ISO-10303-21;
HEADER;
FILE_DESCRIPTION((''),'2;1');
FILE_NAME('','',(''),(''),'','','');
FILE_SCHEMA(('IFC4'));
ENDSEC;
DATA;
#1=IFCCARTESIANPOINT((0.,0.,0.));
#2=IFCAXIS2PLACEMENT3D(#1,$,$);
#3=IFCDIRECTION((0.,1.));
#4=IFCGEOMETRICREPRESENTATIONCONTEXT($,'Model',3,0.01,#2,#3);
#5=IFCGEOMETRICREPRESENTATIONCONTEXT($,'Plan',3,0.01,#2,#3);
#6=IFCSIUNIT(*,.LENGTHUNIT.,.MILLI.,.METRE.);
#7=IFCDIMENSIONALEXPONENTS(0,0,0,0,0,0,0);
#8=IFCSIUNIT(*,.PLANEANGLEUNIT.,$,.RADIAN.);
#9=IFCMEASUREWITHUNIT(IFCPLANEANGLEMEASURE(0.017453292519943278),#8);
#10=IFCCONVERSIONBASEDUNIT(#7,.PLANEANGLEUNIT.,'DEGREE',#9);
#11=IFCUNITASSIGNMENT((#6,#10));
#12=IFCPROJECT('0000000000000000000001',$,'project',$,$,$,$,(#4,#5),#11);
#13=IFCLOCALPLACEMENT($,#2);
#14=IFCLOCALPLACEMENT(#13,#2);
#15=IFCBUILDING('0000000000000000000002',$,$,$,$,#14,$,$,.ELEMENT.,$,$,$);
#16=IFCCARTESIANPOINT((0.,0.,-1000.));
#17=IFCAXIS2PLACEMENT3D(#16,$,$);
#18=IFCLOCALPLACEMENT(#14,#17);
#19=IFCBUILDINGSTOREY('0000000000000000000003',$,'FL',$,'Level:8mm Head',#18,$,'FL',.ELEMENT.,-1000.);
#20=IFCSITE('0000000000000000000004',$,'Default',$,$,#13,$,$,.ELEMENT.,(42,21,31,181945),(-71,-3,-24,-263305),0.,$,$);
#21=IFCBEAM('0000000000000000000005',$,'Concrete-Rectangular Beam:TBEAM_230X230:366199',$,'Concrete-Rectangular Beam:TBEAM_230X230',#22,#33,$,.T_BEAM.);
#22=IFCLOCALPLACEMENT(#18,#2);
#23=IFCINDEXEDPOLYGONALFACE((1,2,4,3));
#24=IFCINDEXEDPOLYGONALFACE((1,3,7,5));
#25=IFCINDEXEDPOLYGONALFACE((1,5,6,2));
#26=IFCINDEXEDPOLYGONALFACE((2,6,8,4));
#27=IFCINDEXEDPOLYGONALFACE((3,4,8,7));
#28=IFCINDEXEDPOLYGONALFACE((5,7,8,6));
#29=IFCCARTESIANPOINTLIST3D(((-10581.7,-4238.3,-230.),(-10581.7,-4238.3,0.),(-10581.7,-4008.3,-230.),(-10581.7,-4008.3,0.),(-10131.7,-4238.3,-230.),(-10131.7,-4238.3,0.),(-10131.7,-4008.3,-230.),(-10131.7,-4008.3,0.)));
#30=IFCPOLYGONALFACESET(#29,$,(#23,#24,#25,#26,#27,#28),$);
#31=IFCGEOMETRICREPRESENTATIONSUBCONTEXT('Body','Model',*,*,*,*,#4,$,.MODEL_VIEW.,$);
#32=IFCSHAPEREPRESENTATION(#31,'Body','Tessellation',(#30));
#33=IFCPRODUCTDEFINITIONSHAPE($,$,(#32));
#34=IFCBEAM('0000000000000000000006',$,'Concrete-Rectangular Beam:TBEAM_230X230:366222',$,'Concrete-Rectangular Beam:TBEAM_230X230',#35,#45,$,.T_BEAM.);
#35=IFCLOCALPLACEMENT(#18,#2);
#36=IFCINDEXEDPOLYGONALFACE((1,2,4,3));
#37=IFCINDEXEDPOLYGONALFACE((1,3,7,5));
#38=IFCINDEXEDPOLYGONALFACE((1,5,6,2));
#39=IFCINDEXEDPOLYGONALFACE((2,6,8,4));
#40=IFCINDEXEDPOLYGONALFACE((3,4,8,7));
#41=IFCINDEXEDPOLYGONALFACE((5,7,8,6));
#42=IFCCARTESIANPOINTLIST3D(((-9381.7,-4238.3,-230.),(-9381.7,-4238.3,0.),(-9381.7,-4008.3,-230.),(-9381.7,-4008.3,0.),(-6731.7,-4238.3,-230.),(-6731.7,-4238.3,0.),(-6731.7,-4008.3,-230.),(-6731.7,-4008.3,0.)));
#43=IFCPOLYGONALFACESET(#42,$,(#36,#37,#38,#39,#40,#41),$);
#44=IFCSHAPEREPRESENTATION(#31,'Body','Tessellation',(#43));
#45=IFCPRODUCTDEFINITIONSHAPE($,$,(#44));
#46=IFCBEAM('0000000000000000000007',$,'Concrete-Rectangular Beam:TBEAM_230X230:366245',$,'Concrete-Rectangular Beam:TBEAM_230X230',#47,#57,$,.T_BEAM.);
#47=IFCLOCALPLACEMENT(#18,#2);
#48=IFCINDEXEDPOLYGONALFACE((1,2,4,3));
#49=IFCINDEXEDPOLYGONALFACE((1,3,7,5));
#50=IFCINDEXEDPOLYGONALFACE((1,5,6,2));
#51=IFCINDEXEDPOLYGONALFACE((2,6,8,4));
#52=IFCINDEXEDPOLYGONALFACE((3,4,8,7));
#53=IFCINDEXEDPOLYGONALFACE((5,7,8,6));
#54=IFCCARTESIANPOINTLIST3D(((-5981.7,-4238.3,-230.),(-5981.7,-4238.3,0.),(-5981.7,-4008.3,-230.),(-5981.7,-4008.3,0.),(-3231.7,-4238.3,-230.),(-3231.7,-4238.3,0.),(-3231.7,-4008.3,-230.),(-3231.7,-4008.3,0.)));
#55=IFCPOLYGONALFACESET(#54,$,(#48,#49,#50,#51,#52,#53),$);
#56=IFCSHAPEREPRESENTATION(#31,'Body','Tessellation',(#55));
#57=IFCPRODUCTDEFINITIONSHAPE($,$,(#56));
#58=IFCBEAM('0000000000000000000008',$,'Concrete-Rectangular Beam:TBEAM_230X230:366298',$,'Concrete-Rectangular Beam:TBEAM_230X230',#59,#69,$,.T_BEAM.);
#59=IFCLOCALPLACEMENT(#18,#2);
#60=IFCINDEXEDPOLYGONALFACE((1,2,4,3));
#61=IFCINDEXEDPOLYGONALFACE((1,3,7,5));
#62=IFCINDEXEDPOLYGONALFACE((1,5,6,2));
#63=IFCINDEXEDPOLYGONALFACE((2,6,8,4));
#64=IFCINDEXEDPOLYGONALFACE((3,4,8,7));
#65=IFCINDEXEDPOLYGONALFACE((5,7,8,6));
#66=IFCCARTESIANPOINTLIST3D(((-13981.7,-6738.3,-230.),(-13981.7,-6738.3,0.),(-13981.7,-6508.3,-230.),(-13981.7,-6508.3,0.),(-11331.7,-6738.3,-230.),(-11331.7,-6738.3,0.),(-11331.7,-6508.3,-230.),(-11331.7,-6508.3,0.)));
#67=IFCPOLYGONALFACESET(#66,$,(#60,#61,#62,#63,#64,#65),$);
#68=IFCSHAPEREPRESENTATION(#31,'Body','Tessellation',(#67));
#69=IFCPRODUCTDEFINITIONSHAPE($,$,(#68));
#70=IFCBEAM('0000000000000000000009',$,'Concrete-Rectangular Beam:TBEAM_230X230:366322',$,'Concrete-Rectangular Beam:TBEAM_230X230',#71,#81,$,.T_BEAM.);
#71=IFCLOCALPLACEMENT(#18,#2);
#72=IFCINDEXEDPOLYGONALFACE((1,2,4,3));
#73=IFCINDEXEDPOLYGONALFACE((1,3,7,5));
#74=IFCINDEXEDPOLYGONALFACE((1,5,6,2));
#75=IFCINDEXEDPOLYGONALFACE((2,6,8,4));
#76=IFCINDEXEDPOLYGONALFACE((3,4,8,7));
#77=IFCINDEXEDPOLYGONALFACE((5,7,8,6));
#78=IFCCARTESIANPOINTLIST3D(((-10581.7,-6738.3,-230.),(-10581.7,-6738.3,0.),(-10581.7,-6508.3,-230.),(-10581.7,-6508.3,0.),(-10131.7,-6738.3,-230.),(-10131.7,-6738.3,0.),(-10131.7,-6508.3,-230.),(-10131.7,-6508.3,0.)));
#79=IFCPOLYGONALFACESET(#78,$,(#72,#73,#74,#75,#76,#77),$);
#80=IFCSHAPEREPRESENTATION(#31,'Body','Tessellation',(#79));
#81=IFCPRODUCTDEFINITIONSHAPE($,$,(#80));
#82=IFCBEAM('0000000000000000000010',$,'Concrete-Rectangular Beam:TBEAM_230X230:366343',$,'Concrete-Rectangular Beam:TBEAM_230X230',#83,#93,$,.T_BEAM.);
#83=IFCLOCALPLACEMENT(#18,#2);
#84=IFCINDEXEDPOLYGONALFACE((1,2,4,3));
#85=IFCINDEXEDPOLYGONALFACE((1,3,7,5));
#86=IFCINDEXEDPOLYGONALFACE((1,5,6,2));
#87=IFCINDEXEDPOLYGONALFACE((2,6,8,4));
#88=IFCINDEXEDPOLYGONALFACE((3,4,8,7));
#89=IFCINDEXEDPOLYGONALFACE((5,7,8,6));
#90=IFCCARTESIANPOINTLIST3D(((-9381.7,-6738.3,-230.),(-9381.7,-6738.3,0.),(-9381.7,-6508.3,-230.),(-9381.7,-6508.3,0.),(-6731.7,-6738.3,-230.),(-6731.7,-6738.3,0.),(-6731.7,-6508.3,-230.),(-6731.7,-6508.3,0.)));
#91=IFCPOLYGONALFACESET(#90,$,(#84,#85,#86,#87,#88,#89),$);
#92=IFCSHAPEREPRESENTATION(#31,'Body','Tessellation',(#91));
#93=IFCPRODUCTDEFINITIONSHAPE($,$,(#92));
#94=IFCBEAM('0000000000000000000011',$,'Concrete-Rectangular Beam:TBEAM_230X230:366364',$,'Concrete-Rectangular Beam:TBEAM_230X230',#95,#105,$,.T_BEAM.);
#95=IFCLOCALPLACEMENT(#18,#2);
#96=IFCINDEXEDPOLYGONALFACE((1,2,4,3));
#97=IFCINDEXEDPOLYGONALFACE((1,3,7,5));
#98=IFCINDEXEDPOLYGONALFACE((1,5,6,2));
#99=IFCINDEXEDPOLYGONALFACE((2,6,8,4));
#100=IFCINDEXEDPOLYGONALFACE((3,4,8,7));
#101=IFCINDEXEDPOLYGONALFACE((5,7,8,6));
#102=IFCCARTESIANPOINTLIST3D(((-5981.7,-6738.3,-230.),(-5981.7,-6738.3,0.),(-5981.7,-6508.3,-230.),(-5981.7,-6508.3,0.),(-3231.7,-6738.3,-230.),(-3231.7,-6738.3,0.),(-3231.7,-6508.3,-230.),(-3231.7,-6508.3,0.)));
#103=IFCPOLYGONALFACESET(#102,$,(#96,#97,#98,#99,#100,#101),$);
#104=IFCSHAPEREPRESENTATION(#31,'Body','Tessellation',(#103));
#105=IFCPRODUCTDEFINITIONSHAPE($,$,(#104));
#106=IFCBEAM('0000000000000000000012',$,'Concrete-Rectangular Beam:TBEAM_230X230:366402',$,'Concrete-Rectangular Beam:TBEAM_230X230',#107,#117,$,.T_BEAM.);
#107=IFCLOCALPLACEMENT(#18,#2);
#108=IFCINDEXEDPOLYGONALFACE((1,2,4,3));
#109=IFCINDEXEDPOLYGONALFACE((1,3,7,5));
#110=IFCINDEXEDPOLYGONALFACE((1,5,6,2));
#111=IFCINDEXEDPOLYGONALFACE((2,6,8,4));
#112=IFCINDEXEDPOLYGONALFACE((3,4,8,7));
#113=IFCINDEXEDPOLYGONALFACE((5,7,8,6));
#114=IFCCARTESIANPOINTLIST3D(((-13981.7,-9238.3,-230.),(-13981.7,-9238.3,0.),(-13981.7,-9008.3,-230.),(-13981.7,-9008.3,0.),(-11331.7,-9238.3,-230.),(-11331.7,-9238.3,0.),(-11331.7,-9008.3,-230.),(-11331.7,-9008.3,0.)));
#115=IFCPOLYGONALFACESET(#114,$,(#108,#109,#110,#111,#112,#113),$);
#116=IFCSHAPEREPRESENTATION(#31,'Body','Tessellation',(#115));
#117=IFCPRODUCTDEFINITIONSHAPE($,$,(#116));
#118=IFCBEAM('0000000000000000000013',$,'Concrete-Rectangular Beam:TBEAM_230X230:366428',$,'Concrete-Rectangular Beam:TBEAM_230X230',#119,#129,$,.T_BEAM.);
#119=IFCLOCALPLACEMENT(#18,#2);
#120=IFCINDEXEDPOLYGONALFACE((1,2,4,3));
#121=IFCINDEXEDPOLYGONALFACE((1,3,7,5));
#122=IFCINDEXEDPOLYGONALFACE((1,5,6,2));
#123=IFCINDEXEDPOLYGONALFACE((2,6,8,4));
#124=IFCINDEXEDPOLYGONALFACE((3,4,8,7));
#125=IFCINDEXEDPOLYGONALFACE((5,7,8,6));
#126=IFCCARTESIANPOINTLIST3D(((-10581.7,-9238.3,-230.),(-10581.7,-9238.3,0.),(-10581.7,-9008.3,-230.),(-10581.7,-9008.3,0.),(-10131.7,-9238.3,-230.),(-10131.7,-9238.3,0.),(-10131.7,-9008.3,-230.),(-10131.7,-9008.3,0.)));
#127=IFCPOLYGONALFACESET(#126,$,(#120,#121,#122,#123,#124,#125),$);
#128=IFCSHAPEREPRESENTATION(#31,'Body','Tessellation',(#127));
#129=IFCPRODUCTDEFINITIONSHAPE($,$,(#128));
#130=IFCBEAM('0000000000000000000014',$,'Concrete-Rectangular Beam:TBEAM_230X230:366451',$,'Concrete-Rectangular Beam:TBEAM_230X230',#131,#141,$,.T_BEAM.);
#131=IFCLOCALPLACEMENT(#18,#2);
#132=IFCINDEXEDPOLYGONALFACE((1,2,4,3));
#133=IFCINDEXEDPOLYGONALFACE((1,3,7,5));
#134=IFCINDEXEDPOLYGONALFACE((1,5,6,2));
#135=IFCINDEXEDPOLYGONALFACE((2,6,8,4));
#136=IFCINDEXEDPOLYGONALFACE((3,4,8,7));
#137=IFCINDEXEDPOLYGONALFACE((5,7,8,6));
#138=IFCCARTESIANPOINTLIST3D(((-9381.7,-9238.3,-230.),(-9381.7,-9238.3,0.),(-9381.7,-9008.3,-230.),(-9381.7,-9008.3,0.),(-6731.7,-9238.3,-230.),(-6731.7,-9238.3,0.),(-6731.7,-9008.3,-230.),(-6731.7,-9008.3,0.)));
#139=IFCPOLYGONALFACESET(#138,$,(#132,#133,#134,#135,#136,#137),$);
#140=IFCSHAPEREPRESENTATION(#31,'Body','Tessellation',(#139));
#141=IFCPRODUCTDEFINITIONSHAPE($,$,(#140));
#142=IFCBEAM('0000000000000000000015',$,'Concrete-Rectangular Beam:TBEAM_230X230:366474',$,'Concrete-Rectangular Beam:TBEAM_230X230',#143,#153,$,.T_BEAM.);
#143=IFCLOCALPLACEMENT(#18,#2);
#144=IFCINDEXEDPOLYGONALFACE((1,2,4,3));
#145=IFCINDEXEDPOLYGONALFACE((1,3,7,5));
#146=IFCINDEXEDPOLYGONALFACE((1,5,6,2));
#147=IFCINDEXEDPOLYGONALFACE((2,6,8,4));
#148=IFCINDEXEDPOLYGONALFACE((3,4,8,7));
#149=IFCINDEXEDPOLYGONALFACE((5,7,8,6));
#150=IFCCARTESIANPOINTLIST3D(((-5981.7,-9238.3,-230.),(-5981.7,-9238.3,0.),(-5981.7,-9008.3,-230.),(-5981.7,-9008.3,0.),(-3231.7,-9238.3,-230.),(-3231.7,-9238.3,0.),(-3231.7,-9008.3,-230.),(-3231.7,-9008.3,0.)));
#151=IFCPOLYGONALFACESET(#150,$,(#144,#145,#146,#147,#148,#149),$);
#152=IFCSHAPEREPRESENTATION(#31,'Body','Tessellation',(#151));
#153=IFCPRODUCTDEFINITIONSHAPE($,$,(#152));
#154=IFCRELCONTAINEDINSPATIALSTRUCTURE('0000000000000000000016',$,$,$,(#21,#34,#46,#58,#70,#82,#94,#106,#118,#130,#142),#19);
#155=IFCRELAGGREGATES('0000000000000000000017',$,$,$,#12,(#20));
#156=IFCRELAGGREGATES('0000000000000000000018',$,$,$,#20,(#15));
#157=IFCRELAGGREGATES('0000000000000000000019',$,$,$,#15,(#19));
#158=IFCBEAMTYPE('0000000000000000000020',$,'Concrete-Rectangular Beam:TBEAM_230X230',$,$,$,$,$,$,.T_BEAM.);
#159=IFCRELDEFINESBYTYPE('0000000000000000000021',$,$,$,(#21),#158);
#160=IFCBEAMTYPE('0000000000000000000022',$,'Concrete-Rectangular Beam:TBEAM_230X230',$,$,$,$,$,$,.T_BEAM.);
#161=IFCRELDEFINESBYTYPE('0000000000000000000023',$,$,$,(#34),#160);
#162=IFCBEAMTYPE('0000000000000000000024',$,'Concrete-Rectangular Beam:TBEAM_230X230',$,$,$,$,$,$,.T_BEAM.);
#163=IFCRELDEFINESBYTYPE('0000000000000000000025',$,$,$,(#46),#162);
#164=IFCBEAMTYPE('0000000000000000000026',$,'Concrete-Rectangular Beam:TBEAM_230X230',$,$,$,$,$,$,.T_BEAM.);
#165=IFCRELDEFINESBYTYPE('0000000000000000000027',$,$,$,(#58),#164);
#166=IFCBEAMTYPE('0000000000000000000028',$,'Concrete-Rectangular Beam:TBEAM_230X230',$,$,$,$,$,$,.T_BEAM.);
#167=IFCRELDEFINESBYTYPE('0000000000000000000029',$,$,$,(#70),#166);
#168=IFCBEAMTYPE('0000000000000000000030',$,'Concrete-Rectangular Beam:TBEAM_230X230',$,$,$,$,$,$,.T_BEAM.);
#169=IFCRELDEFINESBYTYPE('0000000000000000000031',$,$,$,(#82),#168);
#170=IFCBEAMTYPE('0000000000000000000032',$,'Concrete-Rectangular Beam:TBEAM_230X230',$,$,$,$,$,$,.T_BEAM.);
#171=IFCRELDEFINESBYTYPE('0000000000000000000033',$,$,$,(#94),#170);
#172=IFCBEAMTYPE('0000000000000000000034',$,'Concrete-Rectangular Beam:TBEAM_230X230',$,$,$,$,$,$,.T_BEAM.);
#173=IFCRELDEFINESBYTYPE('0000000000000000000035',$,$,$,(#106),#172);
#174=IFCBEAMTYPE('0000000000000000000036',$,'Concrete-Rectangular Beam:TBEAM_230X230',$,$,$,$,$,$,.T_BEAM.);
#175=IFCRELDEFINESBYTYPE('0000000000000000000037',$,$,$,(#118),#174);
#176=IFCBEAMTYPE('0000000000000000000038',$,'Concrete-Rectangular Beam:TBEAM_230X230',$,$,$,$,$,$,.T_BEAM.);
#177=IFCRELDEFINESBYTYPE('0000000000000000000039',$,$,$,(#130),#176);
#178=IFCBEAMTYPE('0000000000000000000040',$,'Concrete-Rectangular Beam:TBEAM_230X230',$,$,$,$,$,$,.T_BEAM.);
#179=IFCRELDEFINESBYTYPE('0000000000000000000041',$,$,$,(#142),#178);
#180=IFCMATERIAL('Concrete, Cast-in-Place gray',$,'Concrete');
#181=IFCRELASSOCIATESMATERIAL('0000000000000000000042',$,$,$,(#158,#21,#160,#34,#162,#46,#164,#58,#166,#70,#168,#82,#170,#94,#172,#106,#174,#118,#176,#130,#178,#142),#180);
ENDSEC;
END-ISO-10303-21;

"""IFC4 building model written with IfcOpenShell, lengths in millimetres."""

from ifc_helpers import new_model, entity, si_unit, converted_unit, direction, frame, origin, place, context, subcontext, project, spatial, indexed_curve, outline, extrude, source, transform, mapped, material, type_object, type_shapes, element, save


model = new_model("IFC4")

# Units and contexts
model_context = context("Model", 3, precision=0.01, world=origin(), true_north=direction((0.0, 1.0)))
plan_context = context("Plan", 3, precision=0.01, world=origin(), true_north=direction((0.0, 1.0)))
body_context = subcontext(model_context, "Body", "Model", "MODEL_VIEW")
ifc_project = project(units=[si_unit("LENGTHUNIT", "METRE", prefix="MILLI"), converted_unit("PLANEANGLEUNIT", "DEGREE", entity("IfcPlaneAngleMeasure", 0.017453292519943278), si_unit("PLANEANGLEUNIT", "RADIAN"), dimensions=[0, 0, 0, 0, 0, 0, 0])], contexts=[model_context, plan_context])

# Site, building, storey
site_placement = place(None, origin())
site = spatial("IfcSite", under=ifc_project, at=site_placement, Name="Default", CompositionType="ELEMENT", RefLatitude=(42, 21, 31, 181945), RefLongitude=(-71, -3, -24, -263305), RefElevation=0.0)
building_placement = place(site_placement, origin())
building = spatial("IfcBuilding", under=site, at=building_placement, CompositionType="ELEMENT")
storey_placement = place(building_placement, frame((0.0, 0.0, -1000.0)))
storey = spatial("IfcBuildingStorey", under=building, at=storey_placement, Name="FL", ObjectType="Level:8mm Head", LongName="FL", CompositionType="ELEMENT", Elevation=-1000.0)

# Shared definitions
ifc_material = material(Name="Concrete, Cast-in-Place gray", Category="Concrete")

# Beams
beam_type_1 = type_object("IfcBeamType", Name="Concrete-Rectangular Beam:TBEAM_230X230", PredefinedType="T_BEAM", material=ifc_material)
shared_shape_1 = source(origin(), body_context, "Body", "SweptSolid", [
    extrude(outline(indexed_curve([(-115.0, -115.0), (115.0, -115.0), (115.0, 115.0), (-115.0, 115.0), (-115.0, -115.0)], self_intersect=False)), frame((-10581.7, -4123.3, -1115.0), z_axis=(1.0, 0.0, 0.0), x_axis=(0.0, 0.0, -1.0)), (0.0, 0.0, 1.0), 450.0),
])
type_shapes(beam_type_1, [shared_shape_1])
beam_1_placement = place(storey_placement, frame((0.0, 0.0, 1000.0)))
element("IfcBeam", 1, at=beam_1_placement, inside=storey, type_object=beam_type_1, material=ifc_material, Name="Concrete-Rectangular Beam:TBEAM_230X230:366199", ObjectType="Concrete-Rectangular Beam:TBEAM_230X230", PredefinedType="T_BEAM", context=body_context, shape_type="MappedRepresentation", body=[
    mapped(shared_shape_1, transform((0.0, 0.0, 0.0), scale=1.0)),
])
beam_type_2 = type_object("IfcBeamType", Name="Concrete-Rectangular Beam:TBEAM_230X230", PredefinedType="T_BEAM", material=ifc_material)
shared_shape_2 = source(origin(), body_context, "Body", "SweptSolid", [
    extrude(outline(indexed_curve([(-115.0, -115.0), (115.0, -115.0), (115.0, 115.0), (-115.0, 115.0), (-115.0, -115.0)], self_intersect=False)), frame((-9381.7, -4123.3, -1115.0), z_axis=(1.0, 0.0, 0.0), x_axis=(0.0, 0.0, -1.0)), (0.0, 0.0, 1.0), 2650.0),
])
type_shapes(beam_type_2, [shared_shape_2])
beam_2_placement = place(storey_placement, frame((0.0, 0.0, 1000.0)))
element("IfcBeam", 2, at=beam_2_placement, inside=storey, type_object=beam_type_2, material=ifc_material, Name="Concrete-Rectangular Beam:TBEAM_230X230:366222", ObjectType="Concrete-Rectangular Beam:TBEAM_230X230", PredefinedType="T_BEAM", context=body_context, shape_type="MappedRepresentation", body=[
    mapped(shared_shape_2, transform((0.0, 0.0, 0.0), scale=1.0)),
])
beam_type_3 = type_object("IfcBeamType", Name="Concrete-Rectangular Beam:TBEAM_230X230", PredefinedType="T_BEAM", material=ifc_material)
shared_shape_3 = source(origin(), body_context, "Body", "SweptSolid", [
    extrude(outline(indexed_curve([(-115.0, -115.0), (115.0, -115.0), (115.0, 115.0), (-115.0, 115.0), (-115.0, -115.0)], self_intersect=False)), frame((-5981.7, -4123.3, -1115.0), z_axis=(1.0, 0.0, 0.0), x_axis=(0.0, 0.0, -1.0)), (0.0, 0.0, 1.0), 2750.0),
])
type_shapes(beam_type_3, [shared_shape_3])
beam_3_placement = place(storey_placement, frame((0.0, 0.0, 1000.0)))
element("IfcBeam", 3, at=beam_3_placement, inside=storey, type_object=beam_type_3, material=ifc_material, Name="Concrete-Rectangular Beam:TBEAM_230X230:366245", ObjectType="Concrete-Rectangular Beam:TBEAM_230X230", PredefinedType="T_BEAM", context=body_context, shape_type="MappedRepresentation", body=[
    mapped(shared_shape_3, transform((0.0, 0.0, 0.0), scale=1.0)),
])
beam_type_4 = type_object("IfcBeamType", Name="Concrete-Rectangular Beam:TBEAM_230X230", PredefinedType="T_BEAM", material=ifc_material)
shared_shape_4 = source(origin(), body_context, "Body", "SweptSolid", [
    extrude(outline(indexed_curve([(-115.0, -115.0), (115.0, -115.0), (115.0, 115.0), (-115.0, 115.0), (-115.0, -115.0)], self_intersect=False)), frame((-13981.7, -6623.3, -1115.0), z_axis=(1.0, 0.0, 0.0), x_axis=(0.0, 0.0, -1.0)), (0.0, 0.0, 1.0), 2650.0),
])
type_shapes(beam_type_4, [shared_shape_4])
beam_4_placement = place(storey_placement, frame((0.0, 0.0, 1000.0)))
element("IfcBeam", 4, at=beam_4_placement, inside=storey, type_object=beam_type_4, material=ifc_material, Name="Concrete-Rectangular Beam:TBEAM_230X230:366298", ObjectType="Concrete-Rectangular Beam:TBEAM_230X230", PredefinedType="T_BEAM", context=body_context, shape_type="MappedRepresentation", body=[
    mapped(shared_shape_4, transform((0.0, 0.0, 0.0), scale=1.0)),
])
beam_type_5 = type_object("IfcBeamType", Name="Concrete-Rectangular Beam:TBEAM_230X230", PredefinedType="T_BEAM", material=ifc_material)
shared_shape_5 = source(origin(), body_context, "Body", "SweptSolid", [
    extrude(outline(indexed_curve([(-115.0, -115.0), (115.0, -115.0), (115.0, 115.0), (-115.0, 115.0), (-115.0, -115.0)], self_intersect=False)), frame((-10581.7, -6623.3, -1115.0), z_axis=(1.0, 0.0, 0.0), x_axis=(0.0, 0.0, -1.0)), (0.0, 0.0, 1.0), 450.0),
])
type_shapes(beam_type_5, [shared_shape_5])
beam_5_placement = place(storey_placement, frame((0.0, 0.0, 1000.0)))
element("IfcBeam", 5, at=beam_5_placement, inside=storey, type_object=beam_type_5, material=ifc_material, Name="Concrete-Rectangular Beam:TBEAM_230X230:366322", ObjectType="Concrete-Rectangular Beam:TBEAM_230X230", PredefinedType="T_BEAM", context=body_context, shape_type="MappedRepresentation", body=[
    mapped(shared_shape_5, transform((0.0, 0.0, 0.0), scale=1.0)),
])
beam_type_6 = type_object("IfcBeamType", Name="Concrete-Rectangular Beam:TBEAM_230X230", PredefinedType="T_BEAM", material=ifc_material)
shared_shape_6 = source(origin(), body_context, "Body", "SweptSolid", [
    extrude(outline(indexed_curve([(-115.0, -115.0), (115.0, -115.0), (115.0, 115.0), (-115.0, 115.0), (-115.0, -115.0)], self_intersect=False)), frame((-9381.7, -6623.3, -1115.0), z_axis=(1.0, 0.0, 0.0), x_axis=(0.0, 0.0, -1.0)), (0.0, 0.0, 1.0), 2650.0),
])
type_shapes(beam_type_6, [shared_shape_6])
beam_6_placement = place(storey_placement, frame((0.0, 0.0, 1000.0)))
element("IfcBeam", 6, at=beam_6_placement, inside=storey, type_object=beam_type_6, material=ifc_material, Name="Concrete-Rectangular Beam:TBEAM_230X230:366343", ObjectType="Concrete-Rectangular Beam:TBEAM_230X230", PredefinedType="T_BEAM", context=body_context, shape_type="MappedRepresentation", body=[
    mapped(shared_shape_6, transform((0.0, 0.0, 0.0), scale=1.0)),
])
beam_type_7 = type_object("IfcBeamType", Name="Concrete-Rectangular Beam:TBEAM_230X230", PredefinedType="T_BEAM", material=ifc_material)
shared_shape_7 = source(origin(), body_context, "Body", "SweptSolid", [
    extrude(outline(indexed_curve([(-115.0, -115.0), (115.0, -115.0), (115.0, 115.0), (-115.0, 115.0), (-115.0, -115.0)], self_intersect=False)), frame((-5981.7, -6623.3, -1115.0), z_axis=(1.0, 0.0, 0.0), x_axis=(0.0, 0.0, -1.0)), (0.0, 0.0, 1.0), 2750.0),
])
type_shapes(beam_type_7, [shared_shape_7])
beam_7_placement = place(storey_placement, frame((0.0, 0.0, 1000.0)))
element("IfcBeam", 7, at=beam_7_placement, inside=storey, type_object=beam_type_7, material=ifc_material, Name="Concrete-Rectangular Beam:TBEAM_230X230:366364", ObjectType="Concrete-Rectangular Beam:TBEAM_230X230", PredefinedType="T_BEAM", context=body_context, shape_type="MappedRepresentation", body=[
    mapped(shared_shape_7, transform((0.0, 0.0, 0.0), scale=1.0)),
])
beam_type_8 = type_object("IfcBeamType", Name="Concrete-Rectangular Beam:TBEAM_230X230", PredefinedType="T_BEAM", material=ifc_material)
shared_shape_8 = source(origin(), body_context, "Body", "SweptSolid", [
    extrude(outline(indexed_curve([(-115.0, -115.0), (115.0, -115.0), (115.0, 115.0), (-115.0, 115.0), (-115.0, -115.0)], self_intersect=False)), frame((-13981.7, -9123.3, -1115.0), z_axis=(1.0, 0.0, 0.0), x_axis=(0.0, 0.0, -1.0)), (0.0, 0.0, 1.0), 2650.0),
])
type_shapes(beam_type_8, [shared_shape_8])
beam_8_placement = place(storey_placement, frame((0.0, 0.0, 1000.0)))
element("IfcBeam", 8, at=beam_8_placement, inside=storey, type_object=beam_type_8, material=ifc_material, Name="Concrete-Rectangular Beam:TBEAM_230X230:366402", ObjectType="Concrete-Rectangular Beam:TBEAM_230X230", PredefinedType="T_BEAM", context=body_context, shape_type="MappedRepresentation", body=[
    mapped(shared_shape_8, transform((0.0, 0.0, 0.0), scale=1.0)),
])
beam_type_9 = type_object("IfcBeamType", Name="Concrete-Rectangular Beam:TBEAM_230X230", PredefinedType="T_BEAM", material=ifc_material)
shared_shape_9 = source(origin(), body_context, "Body", "SweptSolid", [
    extrude(outline(indexed_curve([(-115.0, -115.0), (115.0, -115.0), (115.0, 115.0), (-115.0, 115.0), (-115.0, -115.0)], self_intersect=False)), frame((-10581.7, -9123.3, -1115.0), z_axis=(1.0, 0.0, 0.0), x_axis=(0.0, 0.0, -1.0)), (0.0, 0.0, 1.0), 450.0),
])
type_shapes(beam_type_9, [shared_shape_9])
beam_9_placement = place(storey_placement, frame((0.0, 0.0, 1000.0)))
element("IfcBeam", 9, at=beam_9_placement, inside=storey, type_object=beam_type_9, material=ifc_material, Name="Concrete-Rectangular Beam:TBEAM_230X230:366428", ObjectType="Concrete-Rectangular Beam:TBEAM_230X230", PredefinedType="T_BEAM", context=body_context, shape_type="MappedRepresentation", body=[
    mapped(shared_shape_9, transform((0.0, 0.0, 0.0), scale=1.0)),
])
beam_type_10 = type_object("IfcBeamType", Name="Concrete-Rectangular Beam:TBEAM_230X230", PredefinedType="T_BEAM", material=ifc_material)
shared_shape_10 = source(origin(), body_context, "Body", "SweptSolid", [
    extrude(outline(indexed_curve([(-115.0, -115.0), (115.0, -115.0), (115.0, 115.0), (-115.0, 115.0), (-115.0, -115.0)], self_intersect=False)), frame((-9381.7, -9123.3, -1115.0), z_axis=(1.0, 0.0, 0.0), x_axis=(0.0, 0.0, -1.0)), (0.0, 0.0, 1.0), 2650.0),
])
type_shapes(beam_type_10, [shared_shape_10])
beam_10_placement = place(storey_placement, frame((0.0, 0.0, 1000.0)))
element("IfcBeam", 10, at=beam_10_placement, inside=storey, type_object=beam_type_10, material=ifc_material, Name="Concrete-Rectangular Beam:TBEAM_230X230:366451", ObjectType="Concrete-Rectangular Beam:TBEAM_230X230", PredefinedType="T_BEAM", context=body_context, shape_type="MappedRepresentation", body=[
    mapped(shared_shape_10, transform((0.0, 0.0, 0.0), scale=1.0)),
])
beam_type_11 = type_object("IfcBeamType", Name="Concrete-Rectangular Beam:TBEAM_230X230", PredefinedType="T_BEAM", material=ifc_material)
shared_shape_11 = source(origin(), body_context, "Body", "SweptSolid", [
    extrude(outline(indexed_curve([(-115.0, -115.0), (115.0, -115.0), (115.0, 115.0), (-115.0, 115.0), (-115.0, -115.0)], self_intersect=False)), frame((-5981.7, -9123.3, -1115.0), z_axis=(1.0, 0.0, 0.0), x_axis=(0.0, 0.0, -1.0)), (0.0, 0.0, 1.0), 2750.0),
])
type_shapes(beam_type_11, [shared_shape_11])
beam_11_placement = place(storey_placement, frame((0.0, 0.0, 1000.0)))
element("IfcBeam", 11, at=beam_11_placement, inside=storey, type_object=beam_type_11, material=ifc_material, Name="Concrete-Rectangular Beam:TBEAM_230X230:366474", ObjectType="Concrete-Rectangular Beam:TBEAM_230X230", PredefinedType="T_BEAM", context=body_context, shape_type="MappedRepresentation", body=[
    mapped(shared_shape_11, transform((0.0, 0.0, 0.0), scale=1.0)),
])

save(model, "model.ifc")
